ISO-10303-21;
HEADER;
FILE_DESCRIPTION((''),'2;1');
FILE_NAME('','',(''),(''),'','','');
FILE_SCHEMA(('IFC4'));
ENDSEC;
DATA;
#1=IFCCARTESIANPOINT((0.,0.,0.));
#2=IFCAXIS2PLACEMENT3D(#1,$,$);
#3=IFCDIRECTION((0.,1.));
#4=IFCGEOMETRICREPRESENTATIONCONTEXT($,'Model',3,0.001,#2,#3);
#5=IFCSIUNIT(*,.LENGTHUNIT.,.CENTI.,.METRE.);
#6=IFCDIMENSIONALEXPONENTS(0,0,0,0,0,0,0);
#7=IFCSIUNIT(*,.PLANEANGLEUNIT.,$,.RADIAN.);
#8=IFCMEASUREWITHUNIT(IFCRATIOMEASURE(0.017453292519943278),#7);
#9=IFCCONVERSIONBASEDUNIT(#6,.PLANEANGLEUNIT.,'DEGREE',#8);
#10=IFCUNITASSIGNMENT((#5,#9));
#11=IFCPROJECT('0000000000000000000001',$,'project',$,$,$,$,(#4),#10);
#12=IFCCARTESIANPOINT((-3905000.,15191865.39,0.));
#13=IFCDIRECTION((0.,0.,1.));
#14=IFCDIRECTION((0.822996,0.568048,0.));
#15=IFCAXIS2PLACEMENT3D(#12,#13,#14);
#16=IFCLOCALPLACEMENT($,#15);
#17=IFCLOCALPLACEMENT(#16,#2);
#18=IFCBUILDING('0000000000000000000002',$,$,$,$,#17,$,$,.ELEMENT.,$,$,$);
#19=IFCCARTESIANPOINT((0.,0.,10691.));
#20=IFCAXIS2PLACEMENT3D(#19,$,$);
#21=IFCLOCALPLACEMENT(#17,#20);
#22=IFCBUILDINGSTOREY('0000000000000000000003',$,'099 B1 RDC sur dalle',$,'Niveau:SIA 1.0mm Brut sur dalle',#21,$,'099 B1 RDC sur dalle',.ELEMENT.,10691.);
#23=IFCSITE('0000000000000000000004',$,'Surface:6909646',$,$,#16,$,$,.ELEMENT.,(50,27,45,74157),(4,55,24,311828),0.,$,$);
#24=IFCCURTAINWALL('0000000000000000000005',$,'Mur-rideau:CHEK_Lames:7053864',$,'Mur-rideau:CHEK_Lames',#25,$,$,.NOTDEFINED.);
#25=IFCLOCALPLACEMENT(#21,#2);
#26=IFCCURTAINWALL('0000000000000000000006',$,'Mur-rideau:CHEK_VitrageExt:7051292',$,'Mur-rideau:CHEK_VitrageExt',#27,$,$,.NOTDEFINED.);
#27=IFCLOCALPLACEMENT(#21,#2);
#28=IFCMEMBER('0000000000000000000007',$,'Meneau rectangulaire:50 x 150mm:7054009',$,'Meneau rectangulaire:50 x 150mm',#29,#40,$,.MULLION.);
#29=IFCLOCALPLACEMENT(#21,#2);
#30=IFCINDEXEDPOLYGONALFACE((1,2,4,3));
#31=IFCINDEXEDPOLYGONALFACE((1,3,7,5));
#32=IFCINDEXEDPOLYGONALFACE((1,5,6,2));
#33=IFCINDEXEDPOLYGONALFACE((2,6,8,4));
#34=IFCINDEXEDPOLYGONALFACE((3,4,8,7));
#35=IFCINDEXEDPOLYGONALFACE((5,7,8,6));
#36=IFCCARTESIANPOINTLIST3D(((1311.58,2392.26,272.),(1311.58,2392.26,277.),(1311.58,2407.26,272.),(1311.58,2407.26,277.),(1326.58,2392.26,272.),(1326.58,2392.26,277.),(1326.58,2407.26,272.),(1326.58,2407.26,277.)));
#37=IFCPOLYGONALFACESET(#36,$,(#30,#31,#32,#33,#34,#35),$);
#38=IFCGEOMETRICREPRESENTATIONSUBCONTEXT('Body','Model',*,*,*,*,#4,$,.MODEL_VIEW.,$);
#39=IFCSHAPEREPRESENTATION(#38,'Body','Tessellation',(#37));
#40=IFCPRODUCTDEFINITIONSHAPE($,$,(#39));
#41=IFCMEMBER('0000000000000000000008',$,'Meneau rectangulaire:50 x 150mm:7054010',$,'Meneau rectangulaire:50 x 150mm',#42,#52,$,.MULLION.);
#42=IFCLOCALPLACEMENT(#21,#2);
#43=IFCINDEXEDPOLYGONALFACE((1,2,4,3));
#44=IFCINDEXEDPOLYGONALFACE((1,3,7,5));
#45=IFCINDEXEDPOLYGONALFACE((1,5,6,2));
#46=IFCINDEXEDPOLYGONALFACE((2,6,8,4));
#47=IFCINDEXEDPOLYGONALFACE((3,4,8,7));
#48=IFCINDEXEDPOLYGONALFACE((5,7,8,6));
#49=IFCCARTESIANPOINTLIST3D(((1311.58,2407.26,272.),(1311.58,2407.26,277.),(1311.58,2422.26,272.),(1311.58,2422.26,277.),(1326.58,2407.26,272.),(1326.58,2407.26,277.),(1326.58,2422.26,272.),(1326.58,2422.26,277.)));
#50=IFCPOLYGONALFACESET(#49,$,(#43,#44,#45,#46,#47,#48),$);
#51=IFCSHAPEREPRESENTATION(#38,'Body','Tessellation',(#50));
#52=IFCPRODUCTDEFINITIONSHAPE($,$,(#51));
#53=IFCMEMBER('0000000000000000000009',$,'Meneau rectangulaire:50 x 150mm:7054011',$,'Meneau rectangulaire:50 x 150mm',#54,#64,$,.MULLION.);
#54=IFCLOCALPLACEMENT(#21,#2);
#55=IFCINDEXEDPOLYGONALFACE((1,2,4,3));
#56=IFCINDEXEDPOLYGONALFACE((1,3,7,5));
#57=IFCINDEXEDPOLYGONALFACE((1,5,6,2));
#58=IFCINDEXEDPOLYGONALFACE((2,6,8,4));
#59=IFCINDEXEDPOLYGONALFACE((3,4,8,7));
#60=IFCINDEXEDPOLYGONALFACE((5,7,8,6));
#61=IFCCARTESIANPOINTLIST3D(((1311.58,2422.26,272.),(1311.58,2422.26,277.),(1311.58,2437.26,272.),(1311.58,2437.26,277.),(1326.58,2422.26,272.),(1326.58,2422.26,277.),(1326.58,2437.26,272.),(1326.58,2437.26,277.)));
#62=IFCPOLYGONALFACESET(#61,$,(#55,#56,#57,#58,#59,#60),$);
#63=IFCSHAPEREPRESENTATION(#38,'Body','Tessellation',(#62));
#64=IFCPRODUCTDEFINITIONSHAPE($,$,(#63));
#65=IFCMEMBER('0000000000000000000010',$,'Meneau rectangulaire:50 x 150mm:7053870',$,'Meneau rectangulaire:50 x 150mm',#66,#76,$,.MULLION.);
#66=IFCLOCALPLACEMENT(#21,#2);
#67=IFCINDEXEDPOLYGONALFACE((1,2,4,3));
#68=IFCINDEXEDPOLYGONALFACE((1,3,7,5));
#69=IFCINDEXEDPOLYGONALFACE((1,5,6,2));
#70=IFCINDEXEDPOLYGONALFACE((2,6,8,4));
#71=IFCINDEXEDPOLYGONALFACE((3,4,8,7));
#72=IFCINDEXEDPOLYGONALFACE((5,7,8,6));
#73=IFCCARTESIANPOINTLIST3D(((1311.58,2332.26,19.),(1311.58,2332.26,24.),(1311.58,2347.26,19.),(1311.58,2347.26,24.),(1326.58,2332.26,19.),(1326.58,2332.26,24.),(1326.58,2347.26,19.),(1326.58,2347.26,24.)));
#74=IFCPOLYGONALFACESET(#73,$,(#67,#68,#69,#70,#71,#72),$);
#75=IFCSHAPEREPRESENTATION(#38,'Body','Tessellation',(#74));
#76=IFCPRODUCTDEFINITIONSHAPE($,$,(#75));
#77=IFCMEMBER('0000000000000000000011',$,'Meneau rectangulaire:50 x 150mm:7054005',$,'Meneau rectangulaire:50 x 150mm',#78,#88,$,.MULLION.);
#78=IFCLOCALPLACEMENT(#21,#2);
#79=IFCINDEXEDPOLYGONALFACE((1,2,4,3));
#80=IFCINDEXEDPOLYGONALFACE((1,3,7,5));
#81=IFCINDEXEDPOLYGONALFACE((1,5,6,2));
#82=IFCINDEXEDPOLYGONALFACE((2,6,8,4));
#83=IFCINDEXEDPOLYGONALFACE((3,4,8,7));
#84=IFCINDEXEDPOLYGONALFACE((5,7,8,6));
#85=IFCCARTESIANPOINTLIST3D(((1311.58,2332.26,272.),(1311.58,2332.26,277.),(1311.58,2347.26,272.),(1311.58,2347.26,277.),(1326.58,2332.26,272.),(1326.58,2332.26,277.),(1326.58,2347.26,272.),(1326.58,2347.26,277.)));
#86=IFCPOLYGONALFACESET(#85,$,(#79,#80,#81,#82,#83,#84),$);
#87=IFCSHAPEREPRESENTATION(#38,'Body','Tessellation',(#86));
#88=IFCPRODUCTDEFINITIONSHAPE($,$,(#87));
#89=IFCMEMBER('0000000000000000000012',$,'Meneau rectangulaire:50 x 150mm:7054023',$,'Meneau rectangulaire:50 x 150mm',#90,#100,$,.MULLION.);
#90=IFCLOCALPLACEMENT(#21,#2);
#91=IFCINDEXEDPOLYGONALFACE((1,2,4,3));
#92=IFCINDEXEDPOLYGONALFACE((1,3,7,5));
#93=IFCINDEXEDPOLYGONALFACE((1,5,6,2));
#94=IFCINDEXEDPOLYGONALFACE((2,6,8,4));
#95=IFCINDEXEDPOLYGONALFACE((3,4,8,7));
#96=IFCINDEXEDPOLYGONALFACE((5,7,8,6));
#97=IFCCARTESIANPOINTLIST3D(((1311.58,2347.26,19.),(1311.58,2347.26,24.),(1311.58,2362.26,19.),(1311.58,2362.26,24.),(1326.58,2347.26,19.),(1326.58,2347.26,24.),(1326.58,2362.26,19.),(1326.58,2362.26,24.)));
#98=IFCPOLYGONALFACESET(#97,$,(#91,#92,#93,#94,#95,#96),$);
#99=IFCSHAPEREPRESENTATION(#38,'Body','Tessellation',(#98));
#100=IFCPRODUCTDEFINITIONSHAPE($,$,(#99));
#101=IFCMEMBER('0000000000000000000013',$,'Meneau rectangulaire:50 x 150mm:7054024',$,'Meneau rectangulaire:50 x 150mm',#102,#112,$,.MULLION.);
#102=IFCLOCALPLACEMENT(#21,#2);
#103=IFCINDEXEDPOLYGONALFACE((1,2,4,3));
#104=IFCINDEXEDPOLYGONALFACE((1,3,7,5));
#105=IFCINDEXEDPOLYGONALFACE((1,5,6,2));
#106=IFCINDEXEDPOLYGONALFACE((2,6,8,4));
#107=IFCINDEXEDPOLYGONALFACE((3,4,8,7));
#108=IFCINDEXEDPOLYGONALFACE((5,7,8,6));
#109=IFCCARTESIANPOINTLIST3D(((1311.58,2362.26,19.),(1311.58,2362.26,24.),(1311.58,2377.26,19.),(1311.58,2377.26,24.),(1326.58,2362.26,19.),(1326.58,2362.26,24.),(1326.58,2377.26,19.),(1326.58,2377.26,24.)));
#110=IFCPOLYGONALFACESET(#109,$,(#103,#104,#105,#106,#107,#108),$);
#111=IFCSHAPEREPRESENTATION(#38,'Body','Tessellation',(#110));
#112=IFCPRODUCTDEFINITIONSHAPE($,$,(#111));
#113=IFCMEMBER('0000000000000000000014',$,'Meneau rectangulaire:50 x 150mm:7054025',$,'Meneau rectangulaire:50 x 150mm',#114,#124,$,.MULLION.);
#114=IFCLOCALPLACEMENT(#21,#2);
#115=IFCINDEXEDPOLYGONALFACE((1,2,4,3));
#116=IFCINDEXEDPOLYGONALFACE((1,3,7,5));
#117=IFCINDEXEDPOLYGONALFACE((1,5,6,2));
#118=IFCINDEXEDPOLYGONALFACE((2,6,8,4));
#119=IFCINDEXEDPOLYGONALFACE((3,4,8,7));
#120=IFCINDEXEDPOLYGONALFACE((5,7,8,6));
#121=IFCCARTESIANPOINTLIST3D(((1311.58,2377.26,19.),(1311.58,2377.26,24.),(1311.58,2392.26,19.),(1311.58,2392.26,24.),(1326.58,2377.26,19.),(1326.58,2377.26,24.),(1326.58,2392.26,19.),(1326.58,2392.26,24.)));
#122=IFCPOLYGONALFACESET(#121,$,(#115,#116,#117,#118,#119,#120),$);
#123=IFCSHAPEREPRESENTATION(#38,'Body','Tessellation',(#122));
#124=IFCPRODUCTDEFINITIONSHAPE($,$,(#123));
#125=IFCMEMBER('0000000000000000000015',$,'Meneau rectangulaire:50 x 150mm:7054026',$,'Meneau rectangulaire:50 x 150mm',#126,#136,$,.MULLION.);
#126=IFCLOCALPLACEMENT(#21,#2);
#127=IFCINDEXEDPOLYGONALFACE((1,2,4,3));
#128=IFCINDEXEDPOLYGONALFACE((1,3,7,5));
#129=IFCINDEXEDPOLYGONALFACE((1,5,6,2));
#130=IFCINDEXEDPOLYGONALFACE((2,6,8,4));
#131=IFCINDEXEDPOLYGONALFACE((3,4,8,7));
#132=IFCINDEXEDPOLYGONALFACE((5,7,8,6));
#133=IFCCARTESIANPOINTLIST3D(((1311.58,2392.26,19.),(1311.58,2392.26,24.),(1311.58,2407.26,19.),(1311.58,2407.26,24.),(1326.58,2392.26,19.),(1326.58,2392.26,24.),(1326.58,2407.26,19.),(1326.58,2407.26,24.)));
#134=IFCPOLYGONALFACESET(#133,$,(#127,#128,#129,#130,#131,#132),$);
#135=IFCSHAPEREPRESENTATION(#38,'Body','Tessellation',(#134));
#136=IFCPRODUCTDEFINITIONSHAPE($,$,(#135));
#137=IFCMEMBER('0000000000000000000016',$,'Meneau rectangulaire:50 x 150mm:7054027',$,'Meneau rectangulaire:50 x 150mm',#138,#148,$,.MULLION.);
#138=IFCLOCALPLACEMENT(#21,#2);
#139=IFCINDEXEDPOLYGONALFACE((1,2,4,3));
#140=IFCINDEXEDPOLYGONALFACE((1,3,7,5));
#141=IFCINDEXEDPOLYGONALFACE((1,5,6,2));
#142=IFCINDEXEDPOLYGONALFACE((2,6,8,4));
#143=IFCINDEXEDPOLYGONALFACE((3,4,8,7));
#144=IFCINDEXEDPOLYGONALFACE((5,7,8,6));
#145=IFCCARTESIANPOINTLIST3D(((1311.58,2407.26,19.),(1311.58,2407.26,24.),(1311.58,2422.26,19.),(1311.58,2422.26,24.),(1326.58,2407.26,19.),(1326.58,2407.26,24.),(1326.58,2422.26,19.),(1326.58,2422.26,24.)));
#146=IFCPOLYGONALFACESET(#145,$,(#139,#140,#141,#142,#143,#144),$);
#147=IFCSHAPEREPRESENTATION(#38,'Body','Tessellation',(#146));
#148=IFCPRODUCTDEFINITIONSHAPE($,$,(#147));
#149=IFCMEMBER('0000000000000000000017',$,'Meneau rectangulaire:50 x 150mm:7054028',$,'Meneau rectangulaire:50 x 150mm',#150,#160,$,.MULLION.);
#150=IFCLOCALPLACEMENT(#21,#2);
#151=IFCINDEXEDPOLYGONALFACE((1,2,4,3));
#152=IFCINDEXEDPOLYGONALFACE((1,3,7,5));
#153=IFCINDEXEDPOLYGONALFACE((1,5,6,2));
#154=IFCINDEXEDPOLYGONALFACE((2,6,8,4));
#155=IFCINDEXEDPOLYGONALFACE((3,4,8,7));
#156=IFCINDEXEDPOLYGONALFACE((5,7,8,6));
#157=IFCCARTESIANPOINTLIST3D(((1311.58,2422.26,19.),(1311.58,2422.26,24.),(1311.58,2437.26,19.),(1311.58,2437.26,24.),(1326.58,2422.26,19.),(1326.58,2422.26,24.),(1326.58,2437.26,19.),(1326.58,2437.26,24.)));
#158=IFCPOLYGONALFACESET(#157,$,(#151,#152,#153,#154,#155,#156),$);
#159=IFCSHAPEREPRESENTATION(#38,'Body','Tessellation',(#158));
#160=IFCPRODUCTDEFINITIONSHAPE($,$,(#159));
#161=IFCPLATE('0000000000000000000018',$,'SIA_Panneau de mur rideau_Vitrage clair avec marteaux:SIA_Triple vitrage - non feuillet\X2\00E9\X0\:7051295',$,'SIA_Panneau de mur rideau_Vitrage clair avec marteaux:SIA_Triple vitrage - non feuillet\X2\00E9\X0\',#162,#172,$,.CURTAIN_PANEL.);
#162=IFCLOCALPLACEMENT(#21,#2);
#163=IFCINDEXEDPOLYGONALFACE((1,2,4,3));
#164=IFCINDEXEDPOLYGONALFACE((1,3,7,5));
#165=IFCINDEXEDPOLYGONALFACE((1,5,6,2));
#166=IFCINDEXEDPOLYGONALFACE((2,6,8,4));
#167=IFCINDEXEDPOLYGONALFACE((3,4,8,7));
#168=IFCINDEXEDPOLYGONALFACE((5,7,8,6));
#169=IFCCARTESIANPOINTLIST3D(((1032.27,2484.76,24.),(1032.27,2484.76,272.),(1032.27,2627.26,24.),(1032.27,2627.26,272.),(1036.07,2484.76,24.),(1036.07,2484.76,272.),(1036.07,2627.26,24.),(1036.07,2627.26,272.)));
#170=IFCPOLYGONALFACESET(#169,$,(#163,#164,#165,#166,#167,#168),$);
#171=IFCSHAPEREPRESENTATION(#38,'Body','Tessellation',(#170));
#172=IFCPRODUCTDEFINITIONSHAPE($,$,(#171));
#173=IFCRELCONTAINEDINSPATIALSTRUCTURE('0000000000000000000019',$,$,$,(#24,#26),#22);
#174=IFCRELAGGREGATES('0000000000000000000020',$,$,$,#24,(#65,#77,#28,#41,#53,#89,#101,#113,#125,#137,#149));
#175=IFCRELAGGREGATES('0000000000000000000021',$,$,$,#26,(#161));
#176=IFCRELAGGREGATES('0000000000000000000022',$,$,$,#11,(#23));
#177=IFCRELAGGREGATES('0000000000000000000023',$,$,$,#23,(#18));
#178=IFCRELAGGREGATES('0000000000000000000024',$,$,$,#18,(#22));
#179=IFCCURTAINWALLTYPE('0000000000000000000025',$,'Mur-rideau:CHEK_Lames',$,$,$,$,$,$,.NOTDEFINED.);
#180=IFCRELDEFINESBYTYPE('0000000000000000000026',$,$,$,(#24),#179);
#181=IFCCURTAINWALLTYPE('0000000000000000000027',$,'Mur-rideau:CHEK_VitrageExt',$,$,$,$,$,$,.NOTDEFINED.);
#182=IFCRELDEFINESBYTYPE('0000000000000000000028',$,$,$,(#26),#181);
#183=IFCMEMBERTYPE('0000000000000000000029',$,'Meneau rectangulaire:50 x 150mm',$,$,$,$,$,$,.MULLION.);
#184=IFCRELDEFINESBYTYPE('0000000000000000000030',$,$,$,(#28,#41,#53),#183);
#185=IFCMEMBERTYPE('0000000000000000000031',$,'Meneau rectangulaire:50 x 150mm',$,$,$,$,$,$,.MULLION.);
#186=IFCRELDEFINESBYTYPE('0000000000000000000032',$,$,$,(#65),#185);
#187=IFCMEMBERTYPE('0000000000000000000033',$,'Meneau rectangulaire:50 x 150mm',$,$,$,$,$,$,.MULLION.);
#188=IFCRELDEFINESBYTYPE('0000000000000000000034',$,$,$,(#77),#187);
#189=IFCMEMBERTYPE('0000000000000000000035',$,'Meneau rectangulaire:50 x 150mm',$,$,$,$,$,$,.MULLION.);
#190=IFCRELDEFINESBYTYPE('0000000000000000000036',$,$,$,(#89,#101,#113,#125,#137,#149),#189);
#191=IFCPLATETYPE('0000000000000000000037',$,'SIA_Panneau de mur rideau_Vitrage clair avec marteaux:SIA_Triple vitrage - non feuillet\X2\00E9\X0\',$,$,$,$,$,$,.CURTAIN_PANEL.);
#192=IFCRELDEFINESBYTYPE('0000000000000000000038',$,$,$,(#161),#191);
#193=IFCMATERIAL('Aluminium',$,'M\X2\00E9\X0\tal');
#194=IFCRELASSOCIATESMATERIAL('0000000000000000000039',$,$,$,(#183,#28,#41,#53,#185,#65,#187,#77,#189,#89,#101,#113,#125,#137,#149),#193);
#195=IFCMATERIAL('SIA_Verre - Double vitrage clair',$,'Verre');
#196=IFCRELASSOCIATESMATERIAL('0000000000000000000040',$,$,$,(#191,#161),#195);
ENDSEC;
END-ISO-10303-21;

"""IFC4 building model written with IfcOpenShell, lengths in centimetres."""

from ifc_helpers import new_model, entity, si_unit, converted_unit, direction, frame, origin, place, context, subcontext, project, spatial, indexed_curve, outline, extrude, source, transform, mapped, material, type_object, type_shapes, element, aggregate, save


model = new_model("IFC4")

# Units and contexts
model_context = context("Model", 3, precision=0.001, world=origin(), true_north=direction((0.0, 1.0)))
body_context = subcontext(model_context, "Body", "Model", "MODEL_VIEW")
ifc_project = project(units=[si_unit("LENGTHUNIT", "METRE", prefix="CENTI"), converted_unit("PLANEANGLEUNIT", "DEGREE", entity("IfcRatioMeasure", 0.017453292519943278), si_unit("PLANEANGLEUNIT", "RADIAN"), dimensions=[0, 0, 0, 0, 0, 0, 0])], contexts=[model_context])

# Site, building, storey
site_placement = place(None, frame((-3905000.0, 15191865.39, 0.0), z_axis=(0.0, 0.0, 1.0), x_axis=(0.822996, 0.568048, 0.0)))
site = spatial("IfcSite", under=ifc_project, at=site_placement, Name="Surface:6909646", CompositionType="ELEMENT", RefLatitude=(50, 27, 45, 74157), RefLongitude=(4, 55, 24, 311828), RefElevation=0.0)
building_placement = place(site_placement, origin())
building = spatial("IfcBuilding", under=site, at=building_placement, CompositionType="ELEMENT")
storey_placement = place(building_placement, frame((0.0, 0.0, 10691.0)))
storey = spatial("IfcBuildingStorey", under=building, at=storey_placement, Name="099 B1 RDC sur dalle", ObjectType="Niveau:SIA 1.0mm Brut sur dalle", LongName="099 B1 RDC sur dalle", CompositionType="ELEMENT", Elevation=10691.0)

# Shared definitions
curtain_wall_type_1 = type_object("IfcCurtainWallType", Name="Mur-rideau:CHEK_VitrageExt", PredefinedType="NOTDEFINED")
ifc_material_1 = material(Name="Aluminium", Category="Métal")

# Curtain wall
curtain_wall_type_2 = type_object("IfcCurtainWallType", Name="Mur-rideau:CHEK_Lames", PredefinedType="NOTDEFINED")
curtain_wall_1_placement = place(storey_placement, frame((0.0, 0.0, -10691.0)))
curtain_wall_1 = element("IfcCurtainWall", 1, at=curtain_wall_1_placement, inside=storey, type_object=curtain_wall_type_2, Name="Mur-rideau:CHEK_Lames:7053864", ObjectType="Mur-rideau:CHEK_Lames", PredefinedType="NOTDEFINED")

# Curtain wall
curtain_wall_2_placement = place(storey_placement, frame((0.0, 0.0, -10691.0)))
curtain_wall_2 = element("IfcCurtainWall", 2, at=curtain_wall_2_placement, inside=storey, type_object=curtain_wall_type_1, Name="Mur-rideau:CHEK_VitrageExt:7051292", ObjectType="Mur-rideau:CHEK_VitrageExt", PredefinedType="NOTDEFINED")

# Members
member_type_1 = type_object("IfcMemberType", Name="Meneau rectangulaire:50 x 150mm", PredefinedType="MULLION", material=ifc_material_1)
shared_shape_1 = source(origin(), body_context, "Body", "SweptSolid", [
    extrude(outline(indexed_curve([(-7.5, -2.5), (7.5, -2.5), (7.5, 2.5), (-7.5, 2.5), (-7.5, -2.5)], self_intersect=False)), frame((-2.5, -6.0, -15.0), z_axis=(0.0, 0.0, 1.0), x_axis=(0.0, -1.0, 0.0)), (0.0, 0.0, 1.0), 15.0),
])
type_shapes(member_type_1, [shared_shape_1])
member_1_placement = place(curtain_wall_1_placement, frame((1325.08, 2407.26, 10968.0), z_axis=(0.0, 1.0, 0.0), x_axis=(0.0, 0.0, 1.0)))
member_1 = element("IfcMember", 3, at=member_1_placement, type_object=member_type_1, material=ifc_material_1, Name="Meneau rectangulaire:50 x 150mm:7054009", ObjectType="Meneau rectangulaire:50 x 150mm", PredefinedType="MULLION", context=body_context, shape_type="MappedRepresentation", body=[
    mapped(shared_shape_1, transform((0.0, 0.0, 0.0), scale=1.0)),
])
member_2_placement = place(curtain_wall_1_placement, frame((1325.08, 2422.26, 10968.0), z_axis=(0.0, 1.0, 0.0), x_axis=(0.0, 0.0, 1.0)))
member_2 = element("IfcMember", 4, at=member_2_placement, type_object=member_type_1, material=ifc_material_1, Name="Meneau rectangulaire:50 x 150mm:7054010", ObjectType="Meneau rectangulaire:50 x 150mm", PredefinedType="MULLION", context=body_context, shape_type="MappedRepresentation", body=[
    mapped(shared_shape_1, transform((0.0, 0.0, 0.0), scale=1.0)),
])
member_3_placement = place(curtain_wall_1_placement, frame((1325.08, 2437.26, 10968.0), z_axis=(0.0, 1.0, 0.0), x_axis=(0.0, 0.0, 1.0)))
member_3 = element("IfcMember", 5, at=member_3_placement, type_object=member_type_1, material=ifc_material_1, Name="Meneau rectangulaire:50 x 150mm:7054011", ObjectType="Meneau rectangulaire:50 x 150mm", PredefinedType="MULLION", context=body_context, shape_type="MappedRepresentation", body=[
    mapped(shared_shape_1, transform((0.0, 0.0, 0.0), scale=1.0)),
])
member_type_2 = type_object("IfcMemberType", Name="Meneau rectangulaire:50 x 150mm", PredefinedType="MULLION", material=ifc_material_1)
shared_shape_2 = source(origin(), body_context, "Body", "SweptSolid", [
    extrude(outline(indexed_curve([(-7.5, -2.5), (7.5, -2.5), (7.5, 2.5), (-7.5, 2.5), (-7.5, -2.5)], self_intersect=False)), frame((-2.5, -6.0, -15.0), z_axis=(0.0, 0.0, 1.0), x_axis=(0.0, -1.0, 0.0)), (0.0, 0.0, 1.0), 15.0),
])
type_shapes(member_type_2, [shared_shape_2])
member_4_placement = place(curtain_wall_1_placement, frame((1325.08, 2332.26, 10710.0), z_axis=(0.0, -1.0, 0.0), x_axis=(0.0, 0.0, -1.0)))
member_4 = element("IfcMember", 6, at=member_4_placement, type_object=member_type_2, material=ifc_material_1, Name="Meneau rectangulaire:50 x 150mm:7053870", ObjectType="Meneau rectangulaire:50 x 150mm", PredefinedType="MULLION", context=body_context, shape_type="MappedRepresentation", body=[
    mapped(shared_shape_2, transform((0.0, 0.0, 0.0), scale=1.0)),
])
member_type_3 = type_object("IfcMemberType", Name="Meneau rectangulaire:50 x 150mm", PredefinedType="MULLION", material=ifc_material_1)
shared_shape_3 = source(origin(), body_context, "Body", "SweptSolid", [
    extrude(outline(indexed_curve([(-7.5, -2.5), (7.5, -2.5), (7.5, 2.5), (-7.5, 2.5), (-7.5, -2.5)], self_intersect=False)), frame((-2.5, -6.0, -15.0), z_axis=(0.0, 0.0, 1.0), x_axis=(0.0, -1.0, 0.0)), (0.0, 0.0, 1.0), 15.0),
])
type_shapes(member_type_3, [shared_shape_3])
member_5_placement = place(curtain_wall_1_placement, frame((1325.08, 2347.26, 10968.0), z_axis=(0.0, 1.0, 0.0), x_axis=(0.0, 0.0, 1.0)))
member_5 = element("IfcMember", 7, at=member_5_placement, type_object=member_type_3, material=ifc_material_1, Name="Meneau rectangulaire:50 x 150mm:7054005", ObjectType="Meneau rectangulaire:50 x 150mm", PredefinedType="MULLION", context=body_context, shape_type="MappedRepresentation", body=[
    mapped(shared_shape_3, transform((0.0, 0.0, 0.0), scale=1.0)),
])
member_type_4 = type_object("IfcMemberType", Name="Meneau rectangulaire:50 x 150mm", PredefinedType="MULLION", material=ifc_material_1)
shared_shape_4 = source(origin(), body_context, "Body", "SweptSolid", [
    extrude(outline(indexed_curve([(-7.5, -2.5), (7.5, -2.5), (7.5, 2.5), (-7.5, 2.5), (-7.5, -2.5)], self_intersect=False)), frame((-2.5, -6.0, -15.0), z_axis=(0.0, 0.0, 1.0), x_axis=(0.0, -1.0, 0.0)), (0.0, 0.0, 1.0), 15.0),
])
type_shapes(member_type_4, [shared_shape_4])
member_6_placement = place(curtain_wall_1_placement, frame((1325.08, 2347.26, 10710.0), z_axis=(0.0, -1.0, 0.0), x_axis=(0.0, 0.0, -1.0)))
member_6 = element("IfcMember", 8, at=member_6_placement, type_object=member_type_4, material=ifc_material_1, Name="Meneau rectangulaire:50 x 150mm:7054023", ObjectType="Meneau rectangulaire:50 x 150mm", PredefinedType="MULLION", context=body_context, shape_type="MappedRepresentation", body=[
    mapped(shared_shape_4, transform((0.0, 0.0, 0.0), scale=1.0)),
])
member_7_placement = place(curtain_wall_1_placement, frame((1325.08, 2362.26, 10710.0), z_axis=(0.0, -1.0, 0.0), x_axis=(0.0, 0.0, -1.0)))
member_7 = element("IfcMember", 9, at=member_7_placement, type_object=member_type_4, material=ifc_material_1, Name="Meneau rectangulaire:50 x 150mm:7054024", ObjectType="Meneau rectangulaire:50 x 150mm", PredefinedType="MULLION", context=body_context, shape_type="MappedRepresentation", body=[
    mapped(shared_shape_4, transform((0.0, 0.0, 0.0), scale=1.0)),
])
member_8_placement = place(curtain_wall_1_placement, frame((1325.08, 2377.26, 10710.0), z_axis=(0.0, -1.0, 0.0), x_axis=(0.0, 0.0, -1.0)))
member_8 = element("IfcMember", 10, at=member_8_placement, type_object=member_type_4, material=ifc_material_1, Name="Meneau rectangulaire:50 x 150mm:7054025", ObjectType="Meneau rectangulaire:50 x 150mm", PredefinedType="MULLION", context=body_context, shape_type="MappedRepresentation", body=[
    mapped(shared_shape_4, transform((0.0, 0.0, 0.0), scale=1.0)),
])
member_9_placement = place(curtain_wall_1_placement, frame((1325.08, 2392.26, 10710.0), z_axis=(0.0, -1.0, 0.0), x_axis=(0.0, 0.0, -1.0)))
member_9 = element("IfcMember", 11, at=member_9_placement, type_object=member_type_4, material=ifc_material_1, Name="Meneau rectangulaire:50 x 150mm:7054026", ObjectType="Meneau rectangulaire:50 x 150mm", PredefinedType="MULLION", context=body_context, shape_type="MappedRepresentation", body=[
    mapped(shared_shape_4, transform((0.0, 0.0, 0.0), scale=1.0)),
])
member_10_placement = place(curtain_wall_1_placement, frame((1325.08, 2407.26, 10710.0), z_axis=(0.0, -1.0, 0.0), x_axis=(0.0, 0.0, -1.0)))
member_10 = element("IfcMember", 12, at=member_10_placement, type_object=member_type_4, material=ifc_material_1, Name="Meneau rectangulaire:50 x 150mm:7054027", ObjectType="Meneau rectangulaire:50 x 150mm", PredefinedType="MULLION", context=body_context, shape_type="MappedRepresentation", body=[
    mapped(shared_shape_4, transform((0.0, 0.0, 0.0), scale=1.0)),
])
member_11_placement = place(curtain_wall_1_placement, frame((1325.08, 2422.26, 10710.0), z_axis=(0.0, -1.0, 0.0), x_axis=(0.0, 0.0, -1.0)))
member_11 = element("IfcMember", 13, at=member_11_placement, type_object=member_type_4, material=ifc_material_1, Name="Meneau rectangulaire:50 x 150mm:7054028", ObjectType="Meneau rectangulaire:50 x 150mm", PredefinedType="MULLION", context=body_context, shape_type="MappedRepresentation", body=[
    mapped(shared_shape_4, transform((0.0, 0.0, 0.0), scale=1.0)),
])
aggregate(curtain_wall_1, [member_4, member_5, member_1, member_2, member_3, member_6, member_7, member_8, member_9, member_10, member_11])

# Plate
ifc_material_2 = material(Name="SIA_Verre - Double vitrage clair", Category="Verre")
plate_type = type_object("IfcPlateType", Name="SIA_Panneau de mur rideau_Vitrage clair avec marteaux:SIA_Triple vitrage - non feuilleté", PredefinedType="CURTAIN_PANEL", material=ifc_material_2)
shared_shape_5 = source(origin(), body_context, "Body", "SweptSolid", [
    extrude(outline(indexed_curve([(-71.25, -1.9), (71.25, -1.9), (71.25, 1.9), (-71.25, 1.9), (-71.25, -1.9)], self_intersect=False)), frame((0.0, 1.9, 0.0), z_axis=(0.0, 0.0, 1.0), x_axis=(-1.0, 0.0, 0.0)), (0.0, 0.0, 1.0), 248.0),
])
type_shapes(plate_type, [shared_shape_5])
plate_placement = place(curtain_wall_2_placement, frame((1036.07, 2556.01, 10715.0), z_axis=(0.0, 0.0, 1.0), x_axis=(0.0, 1.0, 0.0)))
plate = element("IfcPlate", 14, at=plate_placement, type_object=plate_type, material=ifc_material_2, Name="SIA_Panneau de mur rideau_Vitrage clair avec marteaux:SIA_Triple vitrage - non feuilleté:7051295", ObjectType="SIA_Panneau de mur rideau_Vitrage clair avec marteaux:SIA_Triple vitrage - non feuilleté", PredefinedType="CURTAIN_PANEL", context=body_context, shape_type="MappedRepresentation", body=[
    mapped(shared_shape_5, transform((0.0, 0.0, 0.0), scale=1.0)),
])
aggregate(curtain_wall_2, [plate])

save(model, "model.ifc")
